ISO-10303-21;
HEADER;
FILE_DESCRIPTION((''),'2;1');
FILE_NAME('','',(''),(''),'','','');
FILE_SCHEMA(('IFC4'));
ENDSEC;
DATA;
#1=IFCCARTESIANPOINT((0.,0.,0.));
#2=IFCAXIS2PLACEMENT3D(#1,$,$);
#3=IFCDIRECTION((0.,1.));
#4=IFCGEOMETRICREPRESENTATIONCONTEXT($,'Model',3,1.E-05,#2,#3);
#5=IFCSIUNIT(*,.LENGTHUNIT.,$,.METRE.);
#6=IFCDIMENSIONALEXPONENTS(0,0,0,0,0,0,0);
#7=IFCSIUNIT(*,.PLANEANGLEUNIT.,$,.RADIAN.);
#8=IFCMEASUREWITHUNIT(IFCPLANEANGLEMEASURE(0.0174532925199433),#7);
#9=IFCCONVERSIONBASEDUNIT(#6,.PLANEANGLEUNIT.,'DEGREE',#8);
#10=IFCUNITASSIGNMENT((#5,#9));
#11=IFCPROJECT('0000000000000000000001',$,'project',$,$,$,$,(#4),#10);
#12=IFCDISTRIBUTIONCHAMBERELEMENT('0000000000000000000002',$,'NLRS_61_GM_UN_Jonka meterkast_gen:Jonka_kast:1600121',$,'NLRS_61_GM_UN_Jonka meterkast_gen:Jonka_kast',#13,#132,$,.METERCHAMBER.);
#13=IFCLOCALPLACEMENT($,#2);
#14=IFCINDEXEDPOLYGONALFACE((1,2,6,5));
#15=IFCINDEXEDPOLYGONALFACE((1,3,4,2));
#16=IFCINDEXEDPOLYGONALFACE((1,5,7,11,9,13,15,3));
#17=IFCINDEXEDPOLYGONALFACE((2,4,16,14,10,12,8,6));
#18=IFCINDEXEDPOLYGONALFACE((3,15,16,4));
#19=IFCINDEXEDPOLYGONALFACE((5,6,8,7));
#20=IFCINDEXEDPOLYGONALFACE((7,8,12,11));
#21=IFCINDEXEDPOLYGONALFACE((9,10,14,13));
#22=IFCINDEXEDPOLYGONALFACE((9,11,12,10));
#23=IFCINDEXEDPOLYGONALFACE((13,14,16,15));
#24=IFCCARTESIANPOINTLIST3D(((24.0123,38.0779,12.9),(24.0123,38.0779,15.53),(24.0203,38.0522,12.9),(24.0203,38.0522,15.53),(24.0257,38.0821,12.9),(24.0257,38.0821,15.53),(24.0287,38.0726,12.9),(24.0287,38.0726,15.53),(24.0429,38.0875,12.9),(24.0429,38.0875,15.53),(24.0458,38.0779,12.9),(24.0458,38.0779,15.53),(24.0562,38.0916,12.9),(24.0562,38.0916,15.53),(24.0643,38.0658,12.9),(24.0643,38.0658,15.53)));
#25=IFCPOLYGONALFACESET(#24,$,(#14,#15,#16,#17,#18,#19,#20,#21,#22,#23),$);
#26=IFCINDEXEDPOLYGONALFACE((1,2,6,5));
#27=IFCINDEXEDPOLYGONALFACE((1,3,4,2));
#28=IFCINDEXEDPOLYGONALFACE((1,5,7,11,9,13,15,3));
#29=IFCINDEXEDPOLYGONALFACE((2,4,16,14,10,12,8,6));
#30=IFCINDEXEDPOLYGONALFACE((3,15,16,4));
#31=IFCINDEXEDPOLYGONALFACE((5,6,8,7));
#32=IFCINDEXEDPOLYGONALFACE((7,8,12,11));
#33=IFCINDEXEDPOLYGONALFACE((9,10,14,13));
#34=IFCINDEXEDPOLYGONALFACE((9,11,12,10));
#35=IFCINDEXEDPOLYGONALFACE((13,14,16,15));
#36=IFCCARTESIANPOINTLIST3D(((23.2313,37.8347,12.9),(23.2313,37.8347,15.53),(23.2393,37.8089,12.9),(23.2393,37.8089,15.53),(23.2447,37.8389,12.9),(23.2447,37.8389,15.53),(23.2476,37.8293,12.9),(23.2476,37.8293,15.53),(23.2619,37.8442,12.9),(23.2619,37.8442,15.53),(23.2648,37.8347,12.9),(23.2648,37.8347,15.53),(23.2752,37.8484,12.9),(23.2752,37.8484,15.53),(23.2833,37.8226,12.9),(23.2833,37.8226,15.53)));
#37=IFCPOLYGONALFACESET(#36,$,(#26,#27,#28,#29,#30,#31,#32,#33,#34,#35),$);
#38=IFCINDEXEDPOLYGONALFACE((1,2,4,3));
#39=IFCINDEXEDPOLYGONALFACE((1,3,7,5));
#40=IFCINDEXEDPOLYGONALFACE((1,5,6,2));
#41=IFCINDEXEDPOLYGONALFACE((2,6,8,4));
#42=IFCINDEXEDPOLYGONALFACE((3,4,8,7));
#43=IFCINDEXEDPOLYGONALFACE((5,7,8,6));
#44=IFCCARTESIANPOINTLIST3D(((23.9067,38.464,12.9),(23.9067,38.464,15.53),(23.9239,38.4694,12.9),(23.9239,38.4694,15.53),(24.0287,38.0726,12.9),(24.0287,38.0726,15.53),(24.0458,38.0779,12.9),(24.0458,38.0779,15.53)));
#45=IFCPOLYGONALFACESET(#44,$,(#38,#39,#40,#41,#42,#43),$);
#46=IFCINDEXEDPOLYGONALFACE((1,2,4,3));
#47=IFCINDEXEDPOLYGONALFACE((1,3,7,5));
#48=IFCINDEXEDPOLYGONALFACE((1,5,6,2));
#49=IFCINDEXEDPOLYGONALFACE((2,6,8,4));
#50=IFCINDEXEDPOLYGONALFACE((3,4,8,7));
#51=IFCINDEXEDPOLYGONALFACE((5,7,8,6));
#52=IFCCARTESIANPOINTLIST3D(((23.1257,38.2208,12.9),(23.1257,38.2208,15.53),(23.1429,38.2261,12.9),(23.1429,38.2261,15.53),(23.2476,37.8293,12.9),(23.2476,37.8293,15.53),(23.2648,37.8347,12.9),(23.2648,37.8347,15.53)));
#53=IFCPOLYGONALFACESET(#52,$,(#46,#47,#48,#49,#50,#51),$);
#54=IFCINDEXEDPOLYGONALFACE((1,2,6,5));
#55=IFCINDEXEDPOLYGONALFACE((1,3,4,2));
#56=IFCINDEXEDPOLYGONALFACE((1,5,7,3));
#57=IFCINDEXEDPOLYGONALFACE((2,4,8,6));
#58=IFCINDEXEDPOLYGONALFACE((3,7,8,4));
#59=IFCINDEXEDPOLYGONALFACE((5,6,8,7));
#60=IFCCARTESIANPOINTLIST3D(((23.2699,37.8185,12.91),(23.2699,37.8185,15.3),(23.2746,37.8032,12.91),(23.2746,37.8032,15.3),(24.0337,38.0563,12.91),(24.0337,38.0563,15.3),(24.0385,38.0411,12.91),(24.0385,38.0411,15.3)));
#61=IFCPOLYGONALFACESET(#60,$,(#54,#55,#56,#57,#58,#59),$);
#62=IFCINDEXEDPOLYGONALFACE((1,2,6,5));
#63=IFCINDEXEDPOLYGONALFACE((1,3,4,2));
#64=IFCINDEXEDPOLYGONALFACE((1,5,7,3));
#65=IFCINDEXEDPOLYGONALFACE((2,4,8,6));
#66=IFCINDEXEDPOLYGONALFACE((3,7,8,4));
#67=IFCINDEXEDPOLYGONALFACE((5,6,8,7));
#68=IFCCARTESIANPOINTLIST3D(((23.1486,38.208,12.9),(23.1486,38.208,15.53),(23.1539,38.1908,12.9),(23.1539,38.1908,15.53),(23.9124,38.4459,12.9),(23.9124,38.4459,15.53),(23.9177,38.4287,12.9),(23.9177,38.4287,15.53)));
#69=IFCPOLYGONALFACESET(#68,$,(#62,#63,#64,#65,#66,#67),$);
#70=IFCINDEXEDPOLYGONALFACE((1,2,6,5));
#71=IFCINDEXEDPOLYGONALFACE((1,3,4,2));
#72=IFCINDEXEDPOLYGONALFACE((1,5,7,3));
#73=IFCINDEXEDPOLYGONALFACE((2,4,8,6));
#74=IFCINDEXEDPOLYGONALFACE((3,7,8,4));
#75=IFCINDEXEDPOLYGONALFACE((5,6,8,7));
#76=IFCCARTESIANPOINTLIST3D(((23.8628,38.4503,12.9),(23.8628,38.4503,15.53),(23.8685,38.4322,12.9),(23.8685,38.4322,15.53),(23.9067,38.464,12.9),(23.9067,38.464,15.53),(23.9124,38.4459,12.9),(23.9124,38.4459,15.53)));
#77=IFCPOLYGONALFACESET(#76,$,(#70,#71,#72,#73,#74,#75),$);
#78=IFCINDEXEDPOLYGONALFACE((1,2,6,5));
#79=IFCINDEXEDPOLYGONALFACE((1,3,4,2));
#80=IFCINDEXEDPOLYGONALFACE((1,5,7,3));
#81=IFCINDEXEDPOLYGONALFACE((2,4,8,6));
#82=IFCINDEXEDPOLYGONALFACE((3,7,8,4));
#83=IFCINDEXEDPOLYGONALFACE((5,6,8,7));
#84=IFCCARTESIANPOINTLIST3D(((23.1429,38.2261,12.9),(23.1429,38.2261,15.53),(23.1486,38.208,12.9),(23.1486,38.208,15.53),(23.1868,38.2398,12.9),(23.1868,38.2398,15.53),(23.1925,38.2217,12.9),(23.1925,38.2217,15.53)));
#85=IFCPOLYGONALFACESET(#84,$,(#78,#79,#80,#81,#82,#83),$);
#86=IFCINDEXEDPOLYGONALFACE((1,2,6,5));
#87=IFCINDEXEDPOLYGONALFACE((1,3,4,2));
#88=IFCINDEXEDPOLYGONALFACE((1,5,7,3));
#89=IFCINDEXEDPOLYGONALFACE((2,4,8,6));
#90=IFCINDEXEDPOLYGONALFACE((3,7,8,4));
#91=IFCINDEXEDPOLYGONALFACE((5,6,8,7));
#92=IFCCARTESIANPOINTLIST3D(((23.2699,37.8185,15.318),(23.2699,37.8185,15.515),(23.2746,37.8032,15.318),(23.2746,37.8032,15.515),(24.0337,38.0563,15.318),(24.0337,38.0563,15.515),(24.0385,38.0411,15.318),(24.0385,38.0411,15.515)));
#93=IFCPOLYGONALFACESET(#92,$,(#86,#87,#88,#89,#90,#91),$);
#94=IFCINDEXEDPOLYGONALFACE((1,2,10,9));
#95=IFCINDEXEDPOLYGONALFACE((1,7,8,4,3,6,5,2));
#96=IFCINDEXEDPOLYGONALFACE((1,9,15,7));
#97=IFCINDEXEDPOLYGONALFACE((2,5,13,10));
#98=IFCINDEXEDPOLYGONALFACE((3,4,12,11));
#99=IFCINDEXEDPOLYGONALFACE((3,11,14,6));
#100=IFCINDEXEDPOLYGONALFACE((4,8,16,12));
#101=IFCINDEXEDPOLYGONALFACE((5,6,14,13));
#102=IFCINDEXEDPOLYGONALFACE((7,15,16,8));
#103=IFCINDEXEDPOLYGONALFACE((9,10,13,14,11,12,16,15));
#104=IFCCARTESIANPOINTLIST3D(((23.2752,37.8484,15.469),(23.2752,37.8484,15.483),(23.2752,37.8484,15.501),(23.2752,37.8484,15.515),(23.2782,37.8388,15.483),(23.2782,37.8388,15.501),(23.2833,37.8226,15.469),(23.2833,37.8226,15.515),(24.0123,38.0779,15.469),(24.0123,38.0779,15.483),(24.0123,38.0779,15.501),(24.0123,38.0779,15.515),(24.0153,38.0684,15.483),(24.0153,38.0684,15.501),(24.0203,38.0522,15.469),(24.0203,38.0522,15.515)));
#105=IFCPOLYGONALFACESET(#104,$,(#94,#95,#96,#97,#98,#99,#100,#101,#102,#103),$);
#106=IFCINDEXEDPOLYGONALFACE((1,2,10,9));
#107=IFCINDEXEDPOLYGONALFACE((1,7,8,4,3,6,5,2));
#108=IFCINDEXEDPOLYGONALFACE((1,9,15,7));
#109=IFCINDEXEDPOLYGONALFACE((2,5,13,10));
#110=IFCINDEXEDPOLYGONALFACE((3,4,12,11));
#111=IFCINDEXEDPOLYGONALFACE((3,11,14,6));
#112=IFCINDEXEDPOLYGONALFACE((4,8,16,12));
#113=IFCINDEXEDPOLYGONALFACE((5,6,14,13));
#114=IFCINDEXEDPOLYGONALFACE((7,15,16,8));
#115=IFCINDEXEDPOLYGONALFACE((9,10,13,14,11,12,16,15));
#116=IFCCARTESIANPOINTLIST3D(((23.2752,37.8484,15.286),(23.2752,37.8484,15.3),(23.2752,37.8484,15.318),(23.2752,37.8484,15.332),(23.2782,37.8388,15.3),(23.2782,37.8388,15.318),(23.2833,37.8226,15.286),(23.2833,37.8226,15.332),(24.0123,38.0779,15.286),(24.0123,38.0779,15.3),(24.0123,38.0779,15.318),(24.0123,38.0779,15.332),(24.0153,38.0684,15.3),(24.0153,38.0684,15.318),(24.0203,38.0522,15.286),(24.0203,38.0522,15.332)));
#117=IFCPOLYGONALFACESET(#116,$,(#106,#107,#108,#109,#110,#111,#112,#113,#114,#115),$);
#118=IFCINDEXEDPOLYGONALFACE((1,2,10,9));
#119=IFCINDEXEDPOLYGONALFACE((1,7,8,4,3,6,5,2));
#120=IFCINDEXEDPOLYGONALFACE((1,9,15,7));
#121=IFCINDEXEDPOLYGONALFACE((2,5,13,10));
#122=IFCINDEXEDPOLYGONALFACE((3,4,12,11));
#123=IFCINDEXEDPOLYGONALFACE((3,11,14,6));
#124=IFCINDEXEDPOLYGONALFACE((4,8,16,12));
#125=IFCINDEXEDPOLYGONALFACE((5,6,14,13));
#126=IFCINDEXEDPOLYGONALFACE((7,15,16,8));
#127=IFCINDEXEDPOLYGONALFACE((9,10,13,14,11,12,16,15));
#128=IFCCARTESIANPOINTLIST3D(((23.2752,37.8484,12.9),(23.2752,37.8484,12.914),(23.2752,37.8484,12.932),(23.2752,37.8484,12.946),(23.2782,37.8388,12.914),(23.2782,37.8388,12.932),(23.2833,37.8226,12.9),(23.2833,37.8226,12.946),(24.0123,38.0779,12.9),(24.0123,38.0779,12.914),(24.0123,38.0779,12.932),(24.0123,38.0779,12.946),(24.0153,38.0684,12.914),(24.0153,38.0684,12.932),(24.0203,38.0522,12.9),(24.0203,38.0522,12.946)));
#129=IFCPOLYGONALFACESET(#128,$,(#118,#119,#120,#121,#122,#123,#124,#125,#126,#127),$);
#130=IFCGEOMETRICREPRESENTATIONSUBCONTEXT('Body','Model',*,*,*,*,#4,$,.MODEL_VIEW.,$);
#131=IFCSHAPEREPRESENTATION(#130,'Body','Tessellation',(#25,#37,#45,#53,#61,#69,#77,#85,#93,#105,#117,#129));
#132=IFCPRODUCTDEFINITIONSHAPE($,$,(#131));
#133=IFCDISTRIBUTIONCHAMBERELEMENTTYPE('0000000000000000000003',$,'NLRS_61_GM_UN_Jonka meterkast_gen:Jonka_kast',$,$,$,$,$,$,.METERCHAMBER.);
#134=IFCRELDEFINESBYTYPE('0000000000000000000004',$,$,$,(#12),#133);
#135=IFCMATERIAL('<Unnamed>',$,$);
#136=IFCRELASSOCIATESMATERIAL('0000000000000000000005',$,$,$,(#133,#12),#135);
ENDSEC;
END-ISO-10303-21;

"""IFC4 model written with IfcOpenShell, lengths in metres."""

from ifc_helpers import new_model, entity, si_unit, converted_unit, direction, frame, origin, place, context, subcontext, project, indexed_curve, outline, extrude, source, transform, mapped, material, type_object, element, save


model = new_model("IFC4")

# Units and contexts
model_context = context("Model", 3, precision=1e-05, world=origin(), true_north=direction((0.0, 1.0)))
body_context = subcontext(model_context, "Body", "Model", "MODEL_VIEW")
ifc_project = project(units=[si_unit("LENGTHUNIT", "METRE"), converted_unit("PLANEANGLEUNIT", "DEGREE", entity("IfcPlaneAngleMeasure", 0.0174532925199433), si_unit("PLANEANGLEUNIT", "RADIAN"), dimensions=[0, 0, 0, 0, 0, 0, 0])], contexts=[model_context])

# Shared definitions
ifc_material = material(Name="<Unnamed>")
distribution_chamber_element_type = type_object("IfcDistributionChamberElementType", Name="NLRS_61_GM_UN_Jonka meterkast_gen:Jonka_kast", PredefinedType="METERCHAMBER", material=ifc_material)
placement_1 = place(None, frame((13.1348, 11.9886, 0.0), z_axis=(0.0, 0.0, 1.0), x_axis=(0.954771, 0.297342, 0.0)))
placement_2 = place(placement_1, origin())
placement_3 = place(placement_2, frame((0.0, 0.0, 12.9)))

# Distribution chamber element
shared_shape_1 = source(origin(), body_context, "Body", "SweptSolid", [
    extrude(outline(indexed_curve([(-0.023, -0.0093), (-0.009, -0.0093), (-0.009, 0.0007), (0.009, 0.0007), (0.009, -0.0093), (0.023, -0.0093), (0.023, 0.0178), (-0.023, 0.0178), (-0.023, -0.0093)], self_intersect=False)), frame((-0.409, 0.4092, 0.0)), (0.0, 0.0, 1.0), 2.63),
    extrude(outline(indexed_curve([(-0.023, -0.0093), (-0.009, -0.0093), (-0.009, 0.0007), (0.009, 0.0007), (0.009, -0.0093), (0.023, -0.0093), (0.023, 0.0178), (-0.023, 0.0178), (-0.023, -0.0093)], self_intersect=False)), frame((0.409, 0.4092, 0.0)), (0.0, 0.0, 1.0), 2.63),
    extrude(outline(indexed_curve([(-0.009, -0.205), (0.009, -0.205), (0.009, 0.205), (-0.009, 0.205), (-0.009, -0.205)], self_intersect=False)), frame((-0.409, 0.205, 0.0)), (0.0, 0.0, 1.0), 2.63),
    extrude(outline(indexed_curve([(-0.009, -0.205), (0.009, -0.205), (0.009, 0.205), (-0.009, 0.205), (-0.009, -0.205)], self_intersect=False)), frame((0.409, 0.205, 0.0)), (0.0, 0.0, 1.0), 2.63),
    extrude(outline(indexed_curve([(-0.008, -0.4), (0.008, -0.4), (0.008, 0.4), (-0.008, 0.4), (-0.008, -0.4)], self_intersect=False)), frame((0.0, 0.435, 0.01), z_axis=(0.0, 0.0, 1.0), x_axis=(0.0, 1.0, 0.0)), (0.0, 0.0, 1.0), 2.39),
    extrude(outline(indexed_curve([(-0.009, -0.4), (0.009, -0.4), (0.009, 0.4), (-0.009, 0.4), (-0.009, -0.4)], self_intersect=False)), frame((0.0, 0.028, 0.0), z_axis=(0.0, 0.0, 1.0), x_axis=(0.0, 1.0, 0.0)), (0.0, 0.0, 1.0), 2.63),
    extrude(outline(indexed_curve([(-0.0095, -0.023), (0.0095, -0.023), (0.0095, 0.023), (-0.0095, 0.023), (-0.0095, -0.023)], self_intersect=False)), frame((-0.377, 0.0095, 0.0), z_axis=(0.0, 0.0, 1.0), x_axis=(0.0, 1.0, 0.0)), (0.0, 0.0, 1.0), 2.63),
    extrude(outline(indexed_curve([(-0.0095, -0.023), (0.0095, -0.023), (0.0095, 0.023), (-0.0095, 0.023), (-0.0095, -0.023)], self_intersect=False)), frame((0.377, 0.0095, 0.0), z_axis=(0.0, 0.0, 1.0), x_axis=(0.0, 1.0, 0.0)), (0.0, 0.0, 1.0), 2.63),
    extrude(outline(indexed_curve([(-0.008, -0.4), (0.008, -0.4), (0.008, 0.4), (-0.008, 0.4), (-0.008, -0.4)], self_intersect=False)), frame((0.0, 0.435, 2.418), z_axis=(0.0, 0.0, 1.0), x_axis=(0.0, 1.0, 0.0)), (0.0, 0.0, 1.0), 0.197),
    extrude(outline(indexed_curve([(-0.0178, -0.023), (0.0093, -0.023), (0.0093, -0.009), (-0.0007, -0.009), (-0.0007, 0.009), (0.0093, 0.009), (0.0093, 0.023), (-0.0178, 0.023), (-0.0178, -0.023)], self_intersect=False)), frame((-0.386, 0.4092, 2.592), z_axis=(1.0, 0.0, 0.0), x_axis=(0.0, -1.0, 0.0)), (0.0, 0.0, 1.0), 0.772),
    extrude(outline(indexed_curve([(-0.0178, -0.023), (0.0093, -0.023), (0.0093, -0.009), (-0.0007, -0.009), (-0.0007, 0.009), (0.0093, 0.009), (0.0093, 0.023), (-0.0178, 0.023), (-0.0178, -0.023)], self_intersect=False)), frame((-0.386, 0.4092, 2.409), z_axis=(1.0, 0.0, 0.0), x_axis=(0.0, -1.0, 0.0)), (0.0, 0.0, 1.0), 0.772),
    extrude(outline(indexed_curve([(-0.0178, -0.023), (0.0093, -0.023), (0.0093, -0.009), (-0.0007, -0.009), (-0.0007, 0.009), (0.0093, 0.009), (0.0093, 0.023), (-0.0178, 0.023), (-0.0178, -0.023)], self_intersect=False)), frame((-0.386, 0.4092, 0.023), z_axis=(1.0, 0.0, 0.0), x_axis=(0.0, -1.0, 0.0)), (0.0, 0.0, 1.0), 0.772),
])
placement_4 = place(placement_3, origin())
distribution_chamber_element_1_placement = place(placement_4, frame((17.757, 22.075, 0.0), z_axis=(0.0, 0.0, 1.0), x_axis=(-1.0, 0.0, 0.0)))
element("IfcDistributionChamberElement", 1, at=distribution_chamber_element_1_placement, type_object=distribution_chamber_element_type, material=ifc_material, Name="NLRS_61_GM_UN_Jonka meterkast_gen:Jonka_kast:1600121", ObjectType="NLRS_61_GM_UN_Jonka meterkast_gen:Jonka_kast", PredefinedType="METERCHAMBER", context=body_context, shape_type="MappedRepresentation", body=[
    mapped(shared_shape_1, transform((0.0, 0.0, 0.0), scale=1.0)),
])

save(model, "model.ifc")
